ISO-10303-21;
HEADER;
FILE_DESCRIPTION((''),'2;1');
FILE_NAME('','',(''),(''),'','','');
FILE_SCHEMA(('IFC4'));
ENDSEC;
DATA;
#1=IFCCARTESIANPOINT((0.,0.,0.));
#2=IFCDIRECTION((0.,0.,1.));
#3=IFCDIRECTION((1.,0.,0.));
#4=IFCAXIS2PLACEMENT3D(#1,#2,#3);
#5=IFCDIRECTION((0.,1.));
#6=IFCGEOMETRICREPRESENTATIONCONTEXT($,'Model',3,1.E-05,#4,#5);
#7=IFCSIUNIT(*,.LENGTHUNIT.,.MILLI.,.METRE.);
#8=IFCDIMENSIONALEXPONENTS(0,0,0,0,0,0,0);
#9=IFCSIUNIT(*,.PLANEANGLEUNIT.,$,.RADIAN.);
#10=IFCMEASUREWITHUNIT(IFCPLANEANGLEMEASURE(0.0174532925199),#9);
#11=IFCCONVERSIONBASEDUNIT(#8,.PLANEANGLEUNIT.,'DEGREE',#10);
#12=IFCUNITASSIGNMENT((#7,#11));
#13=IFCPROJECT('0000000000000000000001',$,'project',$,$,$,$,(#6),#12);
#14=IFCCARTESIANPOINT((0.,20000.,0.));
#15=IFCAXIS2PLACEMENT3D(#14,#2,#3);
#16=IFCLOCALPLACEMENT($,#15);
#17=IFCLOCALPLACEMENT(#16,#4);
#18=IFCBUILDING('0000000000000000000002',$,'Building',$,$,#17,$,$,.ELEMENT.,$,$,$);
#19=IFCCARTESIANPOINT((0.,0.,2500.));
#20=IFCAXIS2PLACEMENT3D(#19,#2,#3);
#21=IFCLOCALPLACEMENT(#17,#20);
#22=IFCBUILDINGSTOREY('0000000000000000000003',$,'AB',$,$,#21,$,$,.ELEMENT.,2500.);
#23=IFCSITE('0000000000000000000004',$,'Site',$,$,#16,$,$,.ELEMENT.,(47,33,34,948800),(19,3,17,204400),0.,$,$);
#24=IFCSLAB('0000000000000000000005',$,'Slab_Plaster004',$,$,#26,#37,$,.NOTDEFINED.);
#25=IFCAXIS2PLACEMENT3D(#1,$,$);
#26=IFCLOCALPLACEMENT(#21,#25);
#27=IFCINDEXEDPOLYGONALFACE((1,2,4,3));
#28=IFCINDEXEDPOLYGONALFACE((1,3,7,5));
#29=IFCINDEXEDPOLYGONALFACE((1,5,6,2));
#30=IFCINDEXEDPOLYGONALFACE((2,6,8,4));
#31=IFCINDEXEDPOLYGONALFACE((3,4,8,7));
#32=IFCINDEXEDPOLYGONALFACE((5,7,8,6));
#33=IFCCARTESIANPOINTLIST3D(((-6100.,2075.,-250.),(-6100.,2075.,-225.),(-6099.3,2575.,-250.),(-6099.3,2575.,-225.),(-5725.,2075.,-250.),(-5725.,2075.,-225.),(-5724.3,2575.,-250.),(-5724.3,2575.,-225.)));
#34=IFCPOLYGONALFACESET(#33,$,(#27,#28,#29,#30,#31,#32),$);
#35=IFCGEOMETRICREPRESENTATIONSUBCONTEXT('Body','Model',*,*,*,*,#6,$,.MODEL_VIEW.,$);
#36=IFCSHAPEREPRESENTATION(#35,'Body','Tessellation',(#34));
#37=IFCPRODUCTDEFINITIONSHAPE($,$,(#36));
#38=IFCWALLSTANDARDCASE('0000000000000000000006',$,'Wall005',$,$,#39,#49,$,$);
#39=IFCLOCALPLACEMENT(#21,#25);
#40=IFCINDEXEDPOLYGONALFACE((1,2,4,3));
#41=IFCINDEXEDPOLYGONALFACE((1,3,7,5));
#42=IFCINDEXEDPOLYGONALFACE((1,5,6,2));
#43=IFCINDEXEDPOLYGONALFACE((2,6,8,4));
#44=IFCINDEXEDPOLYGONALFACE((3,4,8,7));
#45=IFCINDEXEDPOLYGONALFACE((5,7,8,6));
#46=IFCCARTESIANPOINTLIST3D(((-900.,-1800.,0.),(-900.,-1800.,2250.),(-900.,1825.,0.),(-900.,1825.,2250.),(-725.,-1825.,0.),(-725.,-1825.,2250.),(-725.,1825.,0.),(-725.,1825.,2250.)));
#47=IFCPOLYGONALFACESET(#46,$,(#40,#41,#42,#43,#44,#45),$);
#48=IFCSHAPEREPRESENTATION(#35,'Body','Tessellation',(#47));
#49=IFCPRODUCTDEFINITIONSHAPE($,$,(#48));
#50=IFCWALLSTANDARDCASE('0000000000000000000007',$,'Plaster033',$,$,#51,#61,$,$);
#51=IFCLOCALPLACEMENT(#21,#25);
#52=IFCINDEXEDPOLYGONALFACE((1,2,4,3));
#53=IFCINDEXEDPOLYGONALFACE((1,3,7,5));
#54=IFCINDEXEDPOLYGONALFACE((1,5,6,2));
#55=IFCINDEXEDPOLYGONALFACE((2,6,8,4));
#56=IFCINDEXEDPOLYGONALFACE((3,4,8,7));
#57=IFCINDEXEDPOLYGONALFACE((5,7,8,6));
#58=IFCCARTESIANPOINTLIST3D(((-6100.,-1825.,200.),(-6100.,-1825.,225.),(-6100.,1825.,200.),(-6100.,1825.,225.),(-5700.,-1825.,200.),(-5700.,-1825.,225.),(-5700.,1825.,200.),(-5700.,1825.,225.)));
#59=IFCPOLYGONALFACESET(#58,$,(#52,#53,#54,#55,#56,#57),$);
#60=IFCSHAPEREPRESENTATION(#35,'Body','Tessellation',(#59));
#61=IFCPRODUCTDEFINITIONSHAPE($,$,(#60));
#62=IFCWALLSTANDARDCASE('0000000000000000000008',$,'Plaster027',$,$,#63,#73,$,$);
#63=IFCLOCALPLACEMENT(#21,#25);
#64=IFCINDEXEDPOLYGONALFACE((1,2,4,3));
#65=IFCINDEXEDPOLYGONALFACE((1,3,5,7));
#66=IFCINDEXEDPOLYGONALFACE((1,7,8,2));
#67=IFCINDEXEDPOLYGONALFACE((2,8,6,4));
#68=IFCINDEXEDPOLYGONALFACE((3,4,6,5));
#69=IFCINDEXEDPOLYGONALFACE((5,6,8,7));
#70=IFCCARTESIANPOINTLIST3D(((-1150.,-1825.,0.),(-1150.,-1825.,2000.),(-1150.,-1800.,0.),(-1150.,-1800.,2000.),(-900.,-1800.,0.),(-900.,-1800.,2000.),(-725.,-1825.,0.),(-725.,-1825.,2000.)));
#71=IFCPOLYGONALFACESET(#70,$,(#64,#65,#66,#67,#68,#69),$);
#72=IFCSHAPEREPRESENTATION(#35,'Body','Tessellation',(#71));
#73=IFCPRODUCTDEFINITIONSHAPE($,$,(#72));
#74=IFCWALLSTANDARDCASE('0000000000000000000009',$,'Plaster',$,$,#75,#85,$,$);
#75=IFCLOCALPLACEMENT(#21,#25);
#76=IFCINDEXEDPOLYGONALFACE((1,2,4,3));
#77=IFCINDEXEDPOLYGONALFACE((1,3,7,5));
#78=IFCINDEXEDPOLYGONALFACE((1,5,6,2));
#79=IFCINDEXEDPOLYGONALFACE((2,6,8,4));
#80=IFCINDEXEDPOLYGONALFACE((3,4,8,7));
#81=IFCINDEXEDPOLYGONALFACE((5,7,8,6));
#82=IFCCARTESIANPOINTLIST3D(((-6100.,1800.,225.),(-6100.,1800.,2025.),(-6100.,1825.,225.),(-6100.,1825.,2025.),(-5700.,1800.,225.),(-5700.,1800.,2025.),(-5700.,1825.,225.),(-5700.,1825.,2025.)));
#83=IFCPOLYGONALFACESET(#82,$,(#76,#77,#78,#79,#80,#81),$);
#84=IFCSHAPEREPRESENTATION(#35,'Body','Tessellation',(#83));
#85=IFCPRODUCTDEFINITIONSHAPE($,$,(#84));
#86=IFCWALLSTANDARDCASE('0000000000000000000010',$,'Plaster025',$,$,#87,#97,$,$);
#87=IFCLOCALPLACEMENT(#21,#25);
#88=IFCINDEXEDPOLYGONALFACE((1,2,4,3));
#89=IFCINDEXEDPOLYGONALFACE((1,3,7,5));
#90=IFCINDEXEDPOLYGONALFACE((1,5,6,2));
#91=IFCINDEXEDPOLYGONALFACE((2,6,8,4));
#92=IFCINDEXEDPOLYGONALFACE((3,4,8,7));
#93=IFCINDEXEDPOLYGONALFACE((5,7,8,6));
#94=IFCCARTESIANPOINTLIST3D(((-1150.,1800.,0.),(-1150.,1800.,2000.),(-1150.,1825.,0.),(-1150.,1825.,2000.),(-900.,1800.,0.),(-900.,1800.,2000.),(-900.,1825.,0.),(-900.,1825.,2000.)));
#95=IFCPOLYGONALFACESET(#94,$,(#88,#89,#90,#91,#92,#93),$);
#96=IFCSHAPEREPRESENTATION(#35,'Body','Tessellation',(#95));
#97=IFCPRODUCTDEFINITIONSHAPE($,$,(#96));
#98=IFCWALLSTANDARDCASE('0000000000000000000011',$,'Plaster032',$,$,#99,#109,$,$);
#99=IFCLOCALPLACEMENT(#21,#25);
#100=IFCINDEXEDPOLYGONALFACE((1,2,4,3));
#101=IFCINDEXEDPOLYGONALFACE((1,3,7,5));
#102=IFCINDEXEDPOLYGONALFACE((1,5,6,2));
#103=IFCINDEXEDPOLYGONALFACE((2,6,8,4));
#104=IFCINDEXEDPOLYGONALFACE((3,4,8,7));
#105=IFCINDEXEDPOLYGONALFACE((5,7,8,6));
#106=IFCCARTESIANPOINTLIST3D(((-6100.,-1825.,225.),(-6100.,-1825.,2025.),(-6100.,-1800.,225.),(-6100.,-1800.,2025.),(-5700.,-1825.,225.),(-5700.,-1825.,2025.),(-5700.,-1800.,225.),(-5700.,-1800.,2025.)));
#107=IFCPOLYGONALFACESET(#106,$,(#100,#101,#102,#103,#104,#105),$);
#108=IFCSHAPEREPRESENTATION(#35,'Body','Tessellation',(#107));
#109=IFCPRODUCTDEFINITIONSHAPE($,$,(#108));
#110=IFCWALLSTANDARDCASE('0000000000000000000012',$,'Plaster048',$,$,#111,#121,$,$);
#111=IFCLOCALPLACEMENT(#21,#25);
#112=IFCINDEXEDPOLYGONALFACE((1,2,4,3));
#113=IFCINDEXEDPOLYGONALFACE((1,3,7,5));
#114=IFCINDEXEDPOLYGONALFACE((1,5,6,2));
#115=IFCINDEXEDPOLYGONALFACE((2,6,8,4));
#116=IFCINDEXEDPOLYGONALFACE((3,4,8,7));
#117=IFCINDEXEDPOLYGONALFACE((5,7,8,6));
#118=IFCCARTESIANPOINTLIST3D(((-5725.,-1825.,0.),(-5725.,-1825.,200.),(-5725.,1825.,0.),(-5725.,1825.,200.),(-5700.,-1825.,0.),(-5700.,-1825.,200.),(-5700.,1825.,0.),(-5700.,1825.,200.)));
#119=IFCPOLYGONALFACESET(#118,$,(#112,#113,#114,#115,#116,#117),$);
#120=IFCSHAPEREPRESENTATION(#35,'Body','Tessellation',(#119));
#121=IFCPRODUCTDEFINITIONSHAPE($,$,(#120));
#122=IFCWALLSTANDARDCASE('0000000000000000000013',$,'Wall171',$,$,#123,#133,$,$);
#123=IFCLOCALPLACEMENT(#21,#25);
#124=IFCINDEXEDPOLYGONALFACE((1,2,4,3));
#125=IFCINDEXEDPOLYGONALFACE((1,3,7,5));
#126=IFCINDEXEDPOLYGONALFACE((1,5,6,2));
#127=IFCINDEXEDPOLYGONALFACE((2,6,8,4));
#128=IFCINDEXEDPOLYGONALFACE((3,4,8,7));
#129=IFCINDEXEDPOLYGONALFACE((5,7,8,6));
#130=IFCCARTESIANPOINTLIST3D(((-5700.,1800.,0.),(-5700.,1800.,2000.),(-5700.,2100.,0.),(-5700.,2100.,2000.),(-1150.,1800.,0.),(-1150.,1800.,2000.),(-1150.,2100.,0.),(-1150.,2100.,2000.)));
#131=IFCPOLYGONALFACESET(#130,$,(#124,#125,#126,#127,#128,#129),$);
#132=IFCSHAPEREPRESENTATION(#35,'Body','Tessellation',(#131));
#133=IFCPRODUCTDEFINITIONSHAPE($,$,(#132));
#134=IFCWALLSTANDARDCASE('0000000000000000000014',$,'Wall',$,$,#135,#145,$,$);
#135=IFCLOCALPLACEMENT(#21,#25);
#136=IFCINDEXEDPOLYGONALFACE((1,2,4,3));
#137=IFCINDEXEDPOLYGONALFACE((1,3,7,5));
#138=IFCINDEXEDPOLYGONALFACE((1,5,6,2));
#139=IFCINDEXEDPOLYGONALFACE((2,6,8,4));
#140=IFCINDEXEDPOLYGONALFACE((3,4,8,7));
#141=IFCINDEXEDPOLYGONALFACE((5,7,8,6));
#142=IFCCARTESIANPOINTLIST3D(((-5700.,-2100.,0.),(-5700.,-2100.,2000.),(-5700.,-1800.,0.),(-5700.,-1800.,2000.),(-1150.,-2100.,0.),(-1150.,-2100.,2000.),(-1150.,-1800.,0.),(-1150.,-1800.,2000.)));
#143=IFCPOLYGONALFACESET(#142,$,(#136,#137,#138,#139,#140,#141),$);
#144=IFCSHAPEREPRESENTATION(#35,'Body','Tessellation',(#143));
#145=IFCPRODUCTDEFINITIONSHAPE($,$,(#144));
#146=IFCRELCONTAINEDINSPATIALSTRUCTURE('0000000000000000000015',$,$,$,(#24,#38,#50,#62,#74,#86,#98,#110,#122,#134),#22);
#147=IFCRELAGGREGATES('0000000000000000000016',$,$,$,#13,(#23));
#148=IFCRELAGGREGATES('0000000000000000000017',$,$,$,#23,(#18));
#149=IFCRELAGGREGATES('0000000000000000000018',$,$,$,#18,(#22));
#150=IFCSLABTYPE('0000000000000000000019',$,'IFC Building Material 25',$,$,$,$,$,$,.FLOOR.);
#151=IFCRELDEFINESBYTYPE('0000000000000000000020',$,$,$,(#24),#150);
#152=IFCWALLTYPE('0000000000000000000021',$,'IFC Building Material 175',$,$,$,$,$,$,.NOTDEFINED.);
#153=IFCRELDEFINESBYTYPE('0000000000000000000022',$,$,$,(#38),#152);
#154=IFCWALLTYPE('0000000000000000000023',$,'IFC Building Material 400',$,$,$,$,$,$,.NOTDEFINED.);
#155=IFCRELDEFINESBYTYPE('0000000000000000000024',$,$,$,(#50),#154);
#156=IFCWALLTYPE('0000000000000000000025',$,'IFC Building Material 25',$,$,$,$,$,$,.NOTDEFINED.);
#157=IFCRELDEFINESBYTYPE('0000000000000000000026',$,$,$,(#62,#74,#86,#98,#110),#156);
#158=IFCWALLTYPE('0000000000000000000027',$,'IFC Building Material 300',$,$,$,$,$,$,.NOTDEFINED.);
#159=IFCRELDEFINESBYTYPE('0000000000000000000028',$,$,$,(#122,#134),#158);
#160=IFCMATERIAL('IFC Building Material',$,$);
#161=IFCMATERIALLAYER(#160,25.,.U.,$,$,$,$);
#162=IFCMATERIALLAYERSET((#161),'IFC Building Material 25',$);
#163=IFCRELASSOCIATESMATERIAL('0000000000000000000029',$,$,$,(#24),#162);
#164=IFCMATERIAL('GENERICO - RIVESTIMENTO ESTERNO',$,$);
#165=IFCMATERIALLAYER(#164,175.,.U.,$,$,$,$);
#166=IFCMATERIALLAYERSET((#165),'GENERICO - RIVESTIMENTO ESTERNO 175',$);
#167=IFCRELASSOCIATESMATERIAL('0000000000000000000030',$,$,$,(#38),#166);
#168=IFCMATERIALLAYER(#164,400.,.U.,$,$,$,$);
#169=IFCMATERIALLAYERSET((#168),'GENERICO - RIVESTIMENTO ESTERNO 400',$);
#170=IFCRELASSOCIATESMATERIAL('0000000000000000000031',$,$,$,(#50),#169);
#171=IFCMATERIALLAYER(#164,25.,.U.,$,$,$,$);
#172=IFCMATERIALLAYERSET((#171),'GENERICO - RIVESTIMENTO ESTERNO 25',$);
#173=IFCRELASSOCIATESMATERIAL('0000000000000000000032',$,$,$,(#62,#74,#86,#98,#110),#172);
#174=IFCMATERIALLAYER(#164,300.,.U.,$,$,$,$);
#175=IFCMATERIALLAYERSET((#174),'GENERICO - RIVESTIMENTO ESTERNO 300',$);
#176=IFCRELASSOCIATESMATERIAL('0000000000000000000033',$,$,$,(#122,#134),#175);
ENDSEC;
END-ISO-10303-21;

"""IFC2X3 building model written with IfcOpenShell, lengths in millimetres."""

from ifc_helpers import new_model, entity, si_unit, converted_unit, direction, frame, origin_with_axes, place, context, subcontext, project, spatial, polyline, outline, extrude, material, layer, layer_set, layer_usage, type_object, element, save


model = new_model("IFC2X3")

# Units and contexts
model_context = context("Model", 3, precision=1e-05, world=origin_with_axes(), true_north=direction((0.0, 1.0)))
body_context = subcontext(model_context, "Body", "Model", "MODEL_VIEW")
ifc_project = project(units=[si_unit("LENGTHUNIT", "METRE", prefix="MILLI"), converted_unit("PLANEANGLEUNIT", "DEGREE", entity("IfcPlaneAngleMeasure", 0.0174532925199), si_unit("PLANEANGLEUNIT", "RADIAN"), dimensions=[0, 0, 0, 0, 0, 0, 0])], contexts=[model_context])

# Site, building, storey
site_placement = place(None, frame((0.0, 20000.0, 0.0), z_axis=(0.0, 0.0, 1.0), x_axis=(1.0, 0.0, 0.0)))
site = spatial("IfcSite", under=ifc_project, at=site_placement, Name="Site", CompositionType="ELEMENT", RefLatitude=(47, 33, 34, 948800), RefLongitude=(19, 3, 17, 204400), RefElevation=0.0)
building_placement = place(site_placement, origin_with_axes())
building = spatial("IfcBuilding", under=site, at=building_placement, Name="Building", CompositionType="ELEMENT")
storey_placement = place(building_placement, frame((0.0, 0.0, 2500.0), z_axis=(0.0, 0.0, 1.0), x_axis=(1.0, 0.0, 0.0)))
storey = spatial("IfcBuildingStorey", under=building, at=storey_placement, Name="AB", CompositionType="ELEMENT", Elevation=2500.0)

# Shared definitions
ifc_material_1 = material(Name="GENERICO - RIVESTIMENTO ESTERNO")

# Slab
ifc_material_2 = material(Name="IFC Building Material")
ifc_layer_1 = layer(ifc_material_2, 25.0, ventilated="UNKNOWN")
ifc_layer_set_1 = layer_set([ifc_layer_1], Name="IFC Building Material 25")
slab_type_1 = type_object("IfcSlabType", Name="IFC Building Material 25", PredefinedType="FLOOR")
ifc_layer_usage_1 = layer_usage(ifc_layer_set_1, "AXIS3", "NEGATIVE", 25.0)
slab_1_placement = place(storey_placement, frame((-5725.0, 2075.0, -225.0), z_axis=(0.0, 0.0, 1.0), x_axis=(1.0, 0.0, 0.0)))
element("IfcSlab", 1, at=slab_1_placement, inside=storey, type_object=slab_type_1, material=ifc_layer_usage_1, Name="Slab_Plaster004", PredefinedType="NOTDEFINED", context=body_context, shape_type="SweptSolid", body=[
    extrude(outline(polyline([(0.0, 0.0), (0.7, 500.0), (-374.3, 500.0), (-375.0, 0.0), (0.0, 0.0)])), frame((0.0, 0.0, -25.0), z_axis=(0.0, 0.0, 1.0), x_axis=(1.0, 0.0, 0.0)), (0.0, 0.0, 1.0), 25.0),
])

# Walls
ifc_layer_2 = layer(ifc_material_1, 175.0, ventilated="UNKNOWN")
ifc_layer_set_2 = layer_set([ifc_layer_2], Name="GENERICO - RIVESTIMENTO ESTERNO 175")
ifc_layer_usage_2 = layer_usage(ifc_layer_set_2, "AXIS2", "POSITIVE", 0.0)
wall_type_1 = type_object("IfcWallType", Name="IFC Building Material 175", PredefinedType="NOTDEFINED")
wall_1_placement = place(storey_placement, frame((-900.0, 1825.0, 0.0), z_axis=(0.0, 0.0, 1.0), x_axis=(0.0, -1.0, 0.0)))
element("IfcWallStandardCase", 2, at=wall_1_placement, inside=storey, type_object=wall_type_1, material=ifc_layer_usage_2, Name="Wall005", context=body_context, shape_type="SweptSolid", body=[
    extrude(outline(polyline([(0.0, 0.0), (3625.0, 0.0), (3650.0, 175.0), (0.0, 175.0), (0.0, 0.0)])), origin_with_axes(), (0.0, 0.0, 1.0), 2250.0),
])
ifc_layer_3 = layer(ifc_material_1, 400.0, ventilated="UNKNOWN")
ifc_layer_set_3 = layer_set([ifc_layer_3], Name="GENERICO - RIVESTIMENTO ESTERNO 400")
ifc_layer_usage_3 = layer_usage(ifc_layer_set_3, "AXIS2", "POSITIVE", -400.0)
wall_type_2 = type_object("IfcWallType", Name="IFC Building Material 400", PredefinedType="NOTDEFINED")
wall_2_placement = place(storey_placement, frame((-6100.0, -1825.0, 200.0), z_axis=(0.0, 0.0, 1.0), x_axis=(0.0, 1.0, 0.0)))
element("IfcWallStandardCase", 3, at=wall_2_placement, inside=storey, type_object=wall_type_2, material=ifc_layer_usage_3, Name="Plaster033", context=body_context, shape_type="SweptSolid", body=[
    extrude(outline(polyline([(0.0, -400.0), (3650.0, -400.0), (3650.0, 0.0), (0.0, 0.0), (0.0, -400.0)])), origin_with_axes(), (0.0, 0.0, 1.0), 25.0),
])
ifc_layer_4 = layer(ifc_material_1, 25.0, ventilated="UNKNOWN")
ifc_layer_set_4 = layer_set([ifc_layer_4], Name="GENERICO - RIVESTIMENTO ESTERNO 25")
ifc_layer_usage_4 = layer_usage(ifc_layer_set_4, "AXIS2", "POSITIVE", -25.0)
wall_type_3 = type_object("IfcWallType", Name="IFC Building Material 25", PredefinedType="NOTDEFINED")
wall_3_placement = place(storey_placement, frame((-1150.0, -1800.0, 0.0), z_axis=(0.0, 0.0, 1.0), x_axis=(1.0, 0.0, 0.0)))
element("IfcWallStandardCase", 4, at=wall_3_placement, inside=storey, type_object=wall_type_3, material=ifc_layer_usage_4, Name="Plaster027", context=body_context, shape_type="SweptSolid", body=[
    extrude(outline(polyline([(0.0, -25.0), (425.0, -25.0), (250.0, 0.0), (0.0, 0.0), (0.0, -25.0)])), origin_with_axes(), (0.0, 0.0, 1.0), 2000.0),
])
ifc_layer_usage_5 = layer_usage(ifc_layer_set_4, "AXIS2", "POSITIVE", 0.0)
wall_4_placement = place(storey_placement, frame((-6100.0, 1800.0, 225.0), z_axis=(0.0, 0.0, 1.0), x_axis=(1.0, 0.0, 0.0)))
element("IfcWallStandardCase", 5, at=wall_4_placement, inside=storey, type_object=wall_type_3, material=ifc_layer_usage_5, Name="Plaster", context=body_context, shape_type="SweptSolid", body=[
    extrude(outline(polyline([(0.0, 0.0), (400.0, 0.0), (400.0, 25.0), (0.0, 25.0), (0.0, 0.0)])), origin_with_axes(), (0.0, 0.0, 1.0), 1800.0),
])
ifc_layer_usage_6 = layer_usage(ifc_layer_set_4, "AXIS2", "POSITIVE", 0.0)
wall_5_placement = place(storey_placement, frame((-1150.0, 1800.0, 0.0), z_axis=(0.0, 0.0, 1.0), x_axis=(1.0, 0.0, 0.0)))
element("IfcWallStandardCase", 6, at=wall_5_placement, inside=storey, type_object=wall_type_3, material=ifc_layer_usage_6, Name="Plaster025", context=body_context, shape_type="SweptSolid", body=[
    extrude(outline(polyline([(0.0, 0.0), (250.0, 0.0), (250.0, 25.0), (0.0, 25.0), (0.0, 0.0)])), origin_with_axes(), (0.0, 0.0, 1.0), 2000.0),
])
ifc_layer_usage_7 = layer_usage(ifc_layer_set_4, "AXIS2", "POSITIVE", -25.0)
wall_6_placement = place(storey_placement, frame((-6100.0, -1800.0, 225.0), z_axis=(0.0, 0.0, 1.0), x_axis=(1.0, 0.0, 0.0)))
element("IfcWallStandardCase", 7, at=wall_6_placement, inside=storey, type_object=wall_type_3, material=ifc_layer_usage_7, Name="Plaster032", context=body_context, shape_type="SweptSolid", body=[
    extrude(outline(polyline([(0.0, -25.0), (400.0, -25.0), (400.0, 0.0), (0.0, 0.0), (0.0, -25.0)])), origin_with_axes(), (0.0, 0.0, 1.0), 1800.0),
])
ifc_layer_usage_8 = layer_usage(ifc_layer_set_4, "AXIS2", "POSITIVE", -25.0)
wall_7_placement = place(storey_placement, frame((-5725.0, -1825.0, 0.0), z_axis=(0.0, 0.0, 1.0), x_axis=(0.0, 1.0, 0.0)))
element("IfcWallStandardCase", 8, at=wall_7_placement, inside=storey, type_object=wall_type_3, material=ifc_layer_usage_8, Name="Plaster048", context=body_context, shape_type="SweptSolid", body=[
    extrude(outline(polyline([(0.0, -25.0), (3650.0, -25.0), (3650.0, 0.0), (0.0, 0.0), (0.0, -25.0)])), origin_with_axes(), (0.0, 0.0, 1.0), 200.0),
])
ifc_layer_5 = layer(ifc_material_1, 300.0, ventilated="UNKNOWN")
ifc_layer_set_5 = layer_set([ifc_layer_5], Name="GENERICO - RIVESTIMENTO ESTERNO 300")
ifc_layer_usage_9 = layer_usage(ifc_layer_set_5, "AXIS2", "POSITIVE", -300.0)
wall_type_4 = type_object("IfcWallType", Name="IFC Building Material 300", PredefinedType="NOTDEFINED")
wall_8_placement = place(storey_placement, frame((-1150.0, 1800.0, 0.0), z_axis=(0.0, 0.0, 1.0), x_axis=(-1.0, 0.0, 0.0)))
element("IfcWallStandardCase", 9, at=wall_8_placement, inside=storey, type_object=wall_type_4, material=ifc_layer_usage_9, Name="Wall171", context=body_context, shape_type="SweptSolid", body=[
    extrude(outline(polyline([(0.0, -300.0), (4550.0, -300.0), (4550.0, 0.0), (0.0, 0.0), (0.0, -300.0)])), origin_with_axes(), (0.0, 0.0, 1.0), 2000.0),
])
ifc_layer_usage_10 = layer_usage(ifc_layer_set_5, "AXIS2", "POSITIVE", 0.0)
wall_9_placement = place(storey_placement, frame((-1150.0, -1800.0, 0.0), z_axis=(0.0, 0.0, 1.0), x_axis=(-1.0, 0.0, 0.0)))
element("IfcWallStandardCase", 10, at=wall_9_placement, inside=storey, type_object=wall_type_4, material=ifc_layer_usage_10, Name="Wall", context=body_context, shape_type="SweptSolid", body=[
    extrude(outline(polyline([(0.0, 0.0), (4550.0, 0.0), (4550.0, 300.0), (0.0, 300.0), (0.0, 0.0)])), origin_with_axes(), (0.0, 0.0, 1.0), 2000.0),
])

save(model, "model.ifc")
